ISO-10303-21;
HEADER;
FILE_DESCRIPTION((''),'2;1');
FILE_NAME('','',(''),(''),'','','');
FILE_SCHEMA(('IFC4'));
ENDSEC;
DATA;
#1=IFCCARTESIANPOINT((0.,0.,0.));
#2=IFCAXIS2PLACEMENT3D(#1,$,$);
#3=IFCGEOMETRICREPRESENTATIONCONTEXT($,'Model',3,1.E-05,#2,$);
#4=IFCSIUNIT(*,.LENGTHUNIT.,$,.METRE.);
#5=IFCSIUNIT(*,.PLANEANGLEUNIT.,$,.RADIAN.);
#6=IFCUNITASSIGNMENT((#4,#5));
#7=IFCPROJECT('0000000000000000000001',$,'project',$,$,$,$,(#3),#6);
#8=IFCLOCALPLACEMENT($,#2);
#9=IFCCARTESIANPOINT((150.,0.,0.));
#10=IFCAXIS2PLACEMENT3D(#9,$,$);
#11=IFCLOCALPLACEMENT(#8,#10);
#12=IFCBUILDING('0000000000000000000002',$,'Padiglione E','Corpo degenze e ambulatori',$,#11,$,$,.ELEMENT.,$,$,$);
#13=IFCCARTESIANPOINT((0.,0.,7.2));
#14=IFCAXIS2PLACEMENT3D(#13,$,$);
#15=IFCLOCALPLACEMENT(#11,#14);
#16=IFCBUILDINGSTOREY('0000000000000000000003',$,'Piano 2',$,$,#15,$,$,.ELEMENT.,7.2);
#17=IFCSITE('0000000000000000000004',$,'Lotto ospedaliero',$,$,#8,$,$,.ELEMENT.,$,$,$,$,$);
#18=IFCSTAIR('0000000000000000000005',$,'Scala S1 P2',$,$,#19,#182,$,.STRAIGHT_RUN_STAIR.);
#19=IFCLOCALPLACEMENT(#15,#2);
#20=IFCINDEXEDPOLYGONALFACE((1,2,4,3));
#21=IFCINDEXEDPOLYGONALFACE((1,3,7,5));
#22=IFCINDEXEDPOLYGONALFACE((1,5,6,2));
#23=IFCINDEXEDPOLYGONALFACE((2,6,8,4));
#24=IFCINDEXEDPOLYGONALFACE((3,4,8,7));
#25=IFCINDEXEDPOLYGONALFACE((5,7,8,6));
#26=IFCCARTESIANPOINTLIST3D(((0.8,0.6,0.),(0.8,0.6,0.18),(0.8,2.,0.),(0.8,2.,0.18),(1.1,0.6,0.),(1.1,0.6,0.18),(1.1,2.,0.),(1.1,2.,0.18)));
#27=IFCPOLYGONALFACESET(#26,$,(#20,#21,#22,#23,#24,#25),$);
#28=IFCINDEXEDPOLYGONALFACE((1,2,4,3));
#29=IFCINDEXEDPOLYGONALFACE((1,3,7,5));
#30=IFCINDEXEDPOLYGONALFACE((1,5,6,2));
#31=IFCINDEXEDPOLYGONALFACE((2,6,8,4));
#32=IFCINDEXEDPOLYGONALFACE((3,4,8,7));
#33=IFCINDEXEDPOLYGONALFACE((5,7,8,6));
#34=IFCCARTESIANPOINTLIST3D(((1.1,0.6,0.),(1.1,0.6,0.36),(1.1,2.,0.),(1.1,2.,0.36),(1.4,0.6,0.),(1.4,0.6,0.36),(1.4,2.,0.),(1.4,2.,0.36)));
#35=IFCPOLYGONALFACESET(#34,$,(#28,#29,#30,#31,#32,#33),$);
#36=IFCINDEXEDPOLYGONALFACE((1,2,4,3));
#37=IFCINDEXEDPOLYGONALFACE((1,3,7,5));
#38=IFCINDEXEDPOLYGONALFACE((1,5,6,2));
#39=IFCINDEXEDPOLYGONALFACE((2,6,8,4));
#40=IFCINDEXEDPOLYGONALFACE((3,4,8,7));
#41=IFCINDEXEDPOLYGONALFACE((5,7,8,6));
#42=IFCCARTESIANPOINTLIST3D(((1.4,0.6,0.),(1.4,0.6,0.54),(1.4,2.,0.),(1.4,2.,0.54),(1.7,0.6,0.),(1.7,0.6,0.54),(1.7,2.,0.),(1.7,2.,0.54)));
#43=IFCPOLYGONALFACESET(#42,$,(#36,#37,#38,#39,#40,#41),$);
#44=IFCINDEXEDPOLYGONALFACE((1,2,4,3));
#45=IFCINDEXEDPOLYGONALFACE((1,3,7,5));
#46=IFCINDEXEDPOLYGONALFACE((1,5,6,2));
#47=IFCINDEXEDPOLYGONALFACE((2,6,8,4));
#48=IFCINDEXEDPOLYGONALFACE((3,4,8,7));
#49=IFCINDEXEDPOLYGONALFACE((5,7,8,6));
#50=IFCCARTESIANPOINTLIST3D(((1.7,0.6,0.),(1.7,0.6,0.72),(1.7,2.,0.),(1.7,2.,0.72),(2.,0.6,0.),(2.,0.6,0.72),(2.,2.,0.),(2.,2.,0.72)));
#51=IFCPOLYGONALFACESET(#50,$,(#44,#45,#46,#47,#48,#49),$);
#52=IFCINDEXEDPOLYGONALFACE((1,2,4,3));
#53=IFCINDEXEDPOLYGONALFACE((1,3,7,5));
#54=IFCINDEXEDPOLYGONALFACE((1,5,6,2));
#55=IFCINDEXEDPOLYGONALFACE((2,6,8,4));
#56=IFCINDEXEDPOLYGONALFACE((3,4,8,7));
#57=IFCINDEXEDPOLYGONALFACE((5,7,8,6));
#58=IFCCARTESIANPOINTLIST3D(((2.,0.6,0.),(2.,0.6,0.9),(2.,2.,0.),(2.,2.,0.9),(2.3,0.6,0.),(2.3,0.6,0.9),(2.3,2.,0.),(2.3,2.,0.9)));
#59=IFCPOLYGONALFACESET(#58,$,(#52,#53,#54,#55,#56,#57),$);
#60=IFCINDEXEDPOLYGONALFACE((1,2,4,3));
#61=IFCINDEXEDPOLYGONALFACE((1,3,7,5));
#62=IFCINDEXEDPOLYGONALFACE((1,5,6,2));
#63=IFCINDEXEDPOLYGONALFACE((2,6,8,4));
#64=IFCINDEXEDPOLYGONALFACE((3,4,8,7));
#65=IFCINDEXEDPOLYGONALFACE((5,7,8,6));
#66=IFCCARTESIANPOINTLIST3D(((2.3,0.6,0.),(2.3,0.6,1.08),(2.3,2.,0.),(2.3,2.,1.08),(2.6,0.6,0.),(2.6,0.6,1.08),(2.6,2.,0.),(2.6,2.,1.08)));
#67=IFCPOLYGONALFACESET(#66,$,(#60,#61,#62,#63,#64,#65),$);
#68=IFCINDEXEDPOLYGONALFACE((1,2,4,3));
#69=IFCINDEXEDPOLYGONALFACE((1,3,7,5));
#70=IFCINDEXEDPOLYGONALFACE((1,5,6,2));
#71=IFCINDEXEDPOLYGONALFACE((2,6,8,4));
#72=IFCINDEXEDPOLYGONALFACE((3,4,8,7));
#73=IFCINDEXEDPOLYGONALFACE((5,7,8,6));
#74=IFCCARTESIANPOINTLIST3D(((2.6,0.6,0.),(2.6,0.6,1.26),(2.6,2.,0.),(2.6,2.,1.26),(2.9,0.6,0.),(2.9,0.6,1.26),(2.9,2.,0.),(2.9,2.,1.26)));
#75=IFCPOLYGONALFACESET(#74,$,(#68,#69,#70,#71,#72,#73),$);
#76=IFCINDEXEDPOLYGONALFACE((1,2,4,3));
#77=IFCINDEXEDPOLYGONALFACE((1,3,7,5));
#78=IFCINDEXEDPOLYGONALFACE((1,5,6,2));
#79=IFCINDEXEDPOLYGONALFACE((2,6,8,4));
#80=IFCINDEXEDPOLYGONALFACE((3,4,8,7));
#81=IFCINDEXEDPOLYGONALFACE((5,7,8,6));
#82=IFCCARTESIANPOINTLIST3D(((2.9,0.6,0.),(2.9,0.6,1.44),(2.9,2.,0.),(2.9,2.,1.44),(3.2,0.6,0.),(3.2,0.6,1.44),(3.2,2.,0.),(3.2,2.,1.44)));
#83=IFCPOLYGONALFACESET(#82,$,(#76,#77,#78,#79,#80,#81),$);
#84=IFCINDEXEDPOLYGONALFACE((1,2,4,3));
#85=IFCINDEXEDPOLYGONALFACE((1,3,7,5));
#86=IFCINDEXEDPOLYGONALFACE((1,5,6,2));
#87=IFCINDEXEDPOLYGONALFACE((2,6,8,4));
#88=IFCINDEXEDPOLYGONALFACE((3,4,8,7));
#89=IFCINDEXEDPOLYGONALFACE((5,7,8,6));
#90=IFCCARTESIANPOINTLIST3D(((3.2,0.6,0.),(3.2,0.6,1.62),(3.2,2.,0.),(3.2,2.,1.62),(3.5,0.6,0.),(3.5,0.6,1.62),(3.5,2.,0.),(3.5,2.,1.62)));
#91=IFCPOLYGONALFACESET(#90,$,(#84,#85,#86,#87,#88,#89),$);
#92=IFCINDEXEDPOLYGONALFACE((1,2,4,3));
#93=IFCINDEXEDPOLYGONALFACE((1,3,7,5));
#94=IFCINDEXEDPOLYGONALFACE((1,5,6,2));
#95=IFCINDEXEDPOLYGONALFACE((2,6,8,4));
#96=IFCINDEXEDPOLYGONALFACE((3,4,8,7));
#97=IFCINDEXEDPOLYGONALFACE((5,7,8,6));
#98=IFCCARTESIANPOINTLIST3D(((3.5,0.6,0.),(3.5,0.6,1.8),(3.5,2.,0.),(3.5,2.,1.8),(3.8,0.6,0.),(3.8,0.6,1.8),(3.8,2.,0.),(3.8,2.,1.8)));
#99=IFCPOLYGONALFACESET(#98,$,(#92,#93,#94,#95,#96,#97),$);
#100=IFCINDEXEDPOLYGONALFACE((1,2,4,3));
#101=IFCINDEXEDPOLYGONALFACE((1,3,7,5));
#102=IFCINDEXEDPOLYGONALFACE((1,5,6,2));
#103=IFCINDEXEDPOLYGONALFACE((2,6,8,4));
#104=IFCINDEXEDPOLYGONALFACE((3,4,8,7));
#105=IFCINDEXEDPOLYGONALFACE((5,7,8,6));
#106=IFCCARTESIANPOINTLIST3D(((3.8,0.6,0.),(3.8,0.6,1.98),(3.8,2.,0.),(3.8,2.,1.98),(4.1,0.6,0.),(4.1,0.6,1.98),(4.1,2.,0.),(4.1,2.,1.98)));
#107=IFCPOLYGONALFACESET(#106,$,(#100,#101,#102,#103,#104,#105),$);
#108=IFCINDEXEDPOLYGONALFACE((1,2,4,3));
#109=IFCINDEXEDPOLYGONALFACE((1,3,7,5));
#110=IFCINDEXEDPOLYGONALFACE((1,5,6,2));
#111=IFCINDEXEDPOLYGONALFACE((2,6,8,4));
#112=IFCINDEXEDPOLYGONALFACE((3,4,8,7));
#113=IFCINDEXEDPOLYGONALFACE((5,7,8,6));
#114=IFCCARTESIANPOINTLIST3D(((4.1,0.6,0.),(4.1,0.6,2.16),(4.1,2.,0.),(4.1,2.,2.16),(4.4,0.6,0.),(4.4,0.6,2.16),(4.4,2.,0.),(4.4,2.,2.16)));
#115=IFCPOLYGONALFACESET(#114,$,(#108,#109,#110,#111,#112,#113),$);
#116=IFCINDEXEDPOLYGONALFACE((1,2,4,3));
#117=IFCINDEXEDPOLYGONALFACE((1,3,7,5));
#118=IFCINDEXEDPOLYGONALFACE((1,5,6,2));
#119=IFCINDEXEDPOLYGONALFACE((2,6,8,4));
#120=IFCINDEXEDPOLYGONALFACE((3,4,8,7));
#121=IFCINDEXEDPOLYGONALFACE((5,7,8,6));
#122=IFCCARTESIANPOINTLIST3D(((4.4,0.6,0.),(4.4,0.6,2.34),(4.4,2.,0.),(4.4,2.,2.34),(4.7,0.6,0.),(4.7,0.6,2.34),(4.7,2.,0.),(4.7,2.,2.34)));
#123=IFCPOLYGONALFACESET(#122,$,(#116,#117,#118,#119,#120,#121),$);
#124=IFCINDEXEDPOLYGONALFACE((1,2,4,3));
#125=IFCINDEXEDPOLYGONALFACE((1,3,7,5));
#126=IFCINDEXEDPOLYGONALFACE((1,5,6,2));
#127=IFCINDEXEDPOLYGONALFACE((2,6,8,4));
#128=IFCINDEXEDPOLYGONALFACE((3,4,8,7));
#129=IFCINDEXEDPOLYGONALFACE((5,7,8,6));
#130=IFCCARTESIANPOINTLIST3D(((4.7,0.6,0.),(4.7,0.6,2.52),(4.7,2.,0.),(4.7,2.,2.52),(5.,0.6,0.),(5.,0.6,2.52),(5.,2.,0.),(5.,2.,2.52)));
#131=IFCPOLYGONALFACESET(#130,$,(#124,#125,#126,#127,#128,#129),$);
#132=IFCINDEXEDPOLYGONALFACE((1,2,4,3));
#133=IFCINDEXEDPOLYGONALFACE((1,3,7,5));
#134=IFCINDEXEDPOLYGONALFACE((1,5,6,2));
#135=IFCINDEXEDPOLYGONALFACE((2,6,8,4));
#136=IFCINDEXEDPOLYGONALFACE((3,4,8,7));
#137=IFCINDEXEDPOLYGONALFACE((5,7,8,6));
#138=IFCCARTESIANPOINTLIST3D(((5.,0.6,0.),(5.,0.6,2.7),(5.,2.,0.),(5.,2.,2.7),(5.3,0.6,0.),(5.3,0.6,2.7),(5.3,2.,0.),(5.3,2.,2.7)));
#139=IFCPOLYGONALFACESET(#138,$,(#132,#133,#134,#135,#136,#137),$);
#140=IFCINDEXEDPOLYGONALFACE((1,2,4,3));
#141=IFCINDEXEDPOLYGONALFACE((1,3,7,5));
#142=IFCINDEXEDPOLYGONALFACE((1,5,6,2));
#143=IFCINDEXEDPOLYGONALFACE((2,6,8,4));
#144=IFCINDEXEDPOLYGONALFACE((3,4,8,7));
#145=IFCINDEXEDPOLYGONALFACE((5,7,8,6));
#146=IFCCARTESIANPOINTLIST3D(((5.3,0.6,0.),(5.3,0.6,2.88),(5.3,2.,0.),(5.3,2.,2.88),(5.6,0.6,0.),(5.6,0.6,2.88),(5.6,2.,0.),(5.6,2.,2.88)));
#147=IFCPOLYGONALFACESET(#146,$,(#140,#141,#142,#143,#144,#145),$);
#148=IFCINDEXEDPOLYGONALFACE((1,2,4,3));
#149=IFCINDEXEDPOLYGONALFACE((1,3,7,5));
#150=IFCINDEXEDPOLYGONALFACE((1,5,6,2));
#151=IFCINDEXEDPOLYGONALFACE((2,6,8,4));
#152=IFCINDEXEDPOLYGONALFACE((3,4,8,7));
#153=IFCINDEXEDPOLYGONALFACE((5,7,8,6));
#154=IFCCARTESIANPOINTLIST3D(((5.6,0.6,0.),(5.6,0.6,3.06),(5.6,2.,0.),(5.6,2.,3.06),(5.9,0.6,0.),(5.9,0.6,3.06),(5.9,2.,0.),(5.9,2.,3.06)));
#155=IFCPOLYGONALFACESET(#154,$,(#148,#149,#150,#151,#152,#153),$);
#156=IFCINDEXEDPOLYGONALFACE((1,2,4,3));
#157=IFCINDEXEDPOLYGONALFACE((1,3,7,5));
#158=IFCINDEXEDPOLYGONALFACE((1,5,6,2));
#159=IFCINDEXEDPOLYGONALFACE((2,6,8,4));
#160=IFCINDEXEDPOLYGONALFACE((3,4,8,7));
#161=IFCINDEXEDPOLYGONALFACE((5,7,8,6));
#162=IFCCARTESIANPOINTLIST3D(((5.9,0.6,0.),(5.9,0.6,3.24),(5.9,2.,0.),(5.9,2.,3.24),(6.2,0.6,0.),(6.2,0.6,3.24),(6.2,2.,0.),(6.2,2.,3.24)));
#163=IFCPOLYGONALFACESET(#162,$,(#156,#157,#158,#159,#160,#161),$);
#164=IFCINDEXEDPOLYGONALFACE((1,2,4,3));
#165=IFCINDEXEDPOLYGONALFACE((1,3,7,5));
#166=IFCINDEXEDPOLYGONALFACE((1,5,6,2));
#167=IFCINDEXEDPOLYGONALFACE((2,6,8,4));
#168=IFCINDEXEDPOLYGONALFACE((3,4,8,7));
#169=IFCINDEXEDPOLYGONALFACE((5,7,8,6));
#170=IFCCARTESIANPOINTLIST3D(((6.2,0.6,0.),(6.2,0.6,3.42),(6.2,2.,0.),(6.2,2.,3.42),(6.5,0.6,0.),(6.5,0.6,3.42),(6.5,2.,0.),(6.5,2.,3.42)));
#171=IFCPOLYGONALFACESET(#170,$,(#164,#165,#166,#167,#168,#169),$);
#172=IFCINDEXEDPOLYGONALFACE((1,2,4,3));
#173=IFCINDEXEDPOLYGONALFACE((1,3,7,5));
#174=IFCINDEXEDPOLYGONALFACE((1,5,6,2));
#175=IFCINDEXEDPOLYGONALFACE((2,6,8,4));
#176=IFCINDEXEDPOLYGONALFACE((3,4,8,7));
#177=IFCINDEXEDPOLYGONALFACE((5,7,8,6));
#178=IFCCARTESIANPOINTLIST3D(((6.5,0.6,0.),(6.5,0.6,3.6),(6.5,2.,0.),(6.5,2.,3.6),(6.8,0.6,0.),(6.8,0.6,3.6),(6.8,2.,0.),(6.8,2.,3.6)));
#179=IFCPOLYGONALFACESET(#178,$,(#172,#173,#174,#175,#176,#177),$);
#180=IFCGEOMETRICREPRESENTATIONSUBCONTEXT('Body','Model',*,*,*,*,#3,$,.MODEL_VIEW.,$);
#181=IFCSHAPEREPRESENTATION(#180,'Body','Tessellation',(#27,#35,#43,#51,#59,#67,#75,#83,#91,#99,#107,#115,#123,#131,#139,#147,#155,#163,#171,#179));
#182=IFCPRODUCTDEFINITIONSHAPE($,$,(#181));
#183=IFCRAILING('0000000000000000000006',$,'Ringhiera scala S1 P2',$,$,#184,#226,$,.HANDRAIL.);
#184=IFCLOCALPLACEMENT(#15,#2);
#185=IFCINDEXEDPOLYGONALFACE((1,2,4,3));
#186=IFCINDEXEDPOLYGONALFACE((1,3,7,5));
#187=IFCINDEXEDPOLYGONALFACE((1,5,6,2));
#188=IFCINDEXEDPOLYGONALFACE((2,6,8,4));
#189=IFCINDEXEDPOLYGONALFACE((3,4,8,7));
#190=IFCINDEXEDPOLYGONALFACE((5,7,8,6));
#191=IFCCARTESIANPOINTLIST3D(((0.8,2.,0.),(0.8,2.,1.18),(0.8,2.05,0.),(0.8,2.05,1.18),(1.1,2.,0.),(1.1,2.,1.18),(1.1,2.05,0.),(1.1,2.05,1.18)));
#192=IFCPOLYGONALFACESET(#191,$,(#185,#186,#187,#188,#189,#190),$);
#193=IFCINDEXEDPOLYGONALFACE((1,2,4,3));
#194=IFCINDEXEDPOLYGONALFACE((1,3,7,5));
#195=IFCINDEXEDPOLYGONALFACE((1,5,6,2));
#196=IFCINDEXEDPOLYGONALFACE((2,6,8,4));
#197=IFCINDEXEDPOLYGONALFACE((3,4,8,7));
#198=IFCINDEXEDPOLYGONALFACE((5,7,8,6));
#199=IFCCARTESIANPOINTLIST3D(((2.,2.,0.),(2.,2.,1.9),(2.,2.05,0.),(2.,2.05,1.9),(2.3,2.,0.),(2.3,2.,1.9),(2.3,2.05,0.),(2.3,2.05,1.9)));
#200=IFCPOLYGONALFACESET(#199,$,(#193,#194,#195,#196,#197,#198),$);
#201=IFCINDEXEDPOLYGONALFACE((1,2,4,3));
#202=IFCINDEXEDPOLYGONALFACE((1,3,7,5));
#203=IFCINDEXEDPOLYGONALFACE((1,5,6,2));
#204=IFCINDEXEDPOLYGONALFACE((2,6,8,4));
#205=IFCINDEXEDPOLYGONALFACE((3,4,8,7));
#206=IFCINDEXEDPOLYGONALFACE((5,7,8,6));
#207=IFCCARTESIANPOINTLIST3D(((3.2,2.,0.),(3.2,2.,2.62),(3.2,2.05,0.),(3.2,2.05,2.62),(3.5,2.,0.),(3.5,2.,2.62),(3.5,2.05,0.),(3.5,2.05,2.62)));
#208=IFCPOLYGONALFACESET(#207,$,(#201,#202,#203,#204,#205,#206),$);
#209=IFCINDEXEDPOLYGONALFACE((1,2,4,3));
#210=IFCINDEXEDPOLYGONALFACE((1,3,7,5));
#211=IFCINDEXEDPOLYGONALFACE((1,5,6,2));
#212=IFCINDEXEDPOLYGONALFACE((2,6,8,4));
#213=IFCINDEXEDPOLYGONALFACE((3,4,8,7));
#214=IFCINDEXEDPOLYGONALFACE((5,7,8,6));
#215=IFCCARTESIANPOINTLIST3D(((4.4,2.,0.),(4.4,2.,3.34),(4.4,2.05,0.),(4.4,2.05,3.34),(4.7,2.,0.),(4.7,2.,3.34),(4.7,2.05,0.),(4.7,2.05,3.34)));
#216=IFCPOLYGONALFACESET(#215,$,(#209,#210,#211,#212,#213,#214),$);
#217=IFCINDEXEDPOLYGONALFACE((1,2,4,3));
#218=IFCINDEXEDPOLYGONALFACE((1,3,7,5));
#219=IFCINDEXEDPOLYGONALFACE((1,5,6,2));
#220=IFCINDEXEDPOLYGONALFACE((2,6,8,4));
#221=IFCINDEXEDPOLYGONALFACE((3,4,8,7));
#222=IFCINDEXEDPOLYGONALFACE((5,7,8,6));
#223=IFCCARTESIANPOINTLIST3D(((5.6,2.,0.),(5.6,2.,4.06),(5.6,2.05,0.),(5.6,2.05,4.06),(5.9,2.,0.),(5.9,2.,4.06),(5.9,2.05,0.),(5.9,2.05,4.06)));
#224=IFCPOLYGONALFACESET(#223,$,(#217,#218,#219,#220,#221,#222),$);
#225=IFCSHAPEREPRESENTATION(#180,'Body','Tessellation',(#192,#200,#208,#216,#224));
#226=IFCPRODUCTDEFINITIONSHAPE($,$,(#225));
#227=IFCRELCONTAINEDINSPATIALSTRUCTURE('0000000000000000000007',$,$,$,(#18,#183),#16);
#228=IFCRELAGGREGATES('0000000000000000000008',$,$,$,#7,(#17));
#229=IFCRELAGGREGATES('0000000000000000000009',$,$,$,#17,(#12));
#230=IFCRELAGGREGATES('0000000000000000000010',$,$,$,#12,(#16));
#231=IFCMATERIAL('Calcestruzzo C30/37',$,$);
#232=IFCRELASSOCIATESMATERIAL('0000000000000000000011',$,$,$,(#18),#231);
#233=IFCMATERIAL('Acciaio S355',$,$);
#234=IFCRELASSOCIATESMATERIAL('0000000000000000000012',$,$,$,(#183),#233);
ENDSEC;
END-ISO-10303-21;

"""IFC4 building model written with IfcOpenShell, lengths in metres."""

from ifc_helpers import new_model, si_unit, frame, frame_2d, origin, place, context, subcontext, project, spatial, rectangle, extrude, material, element, save


model = new_model("IFC4")

# Units and contexts
model_context = context("Model", 3, precision=1e-05, world=origin())
body_context = subcontext(model_context, "Body", "Model", "MODEL_VIEW")
ifc_project = project(units=[si_unit("LENGTHUNIT", "METRE"), si_unit("PLANEANGLEUNIT", "RADIAN")], contexts=[model_context])

# Site, building, storey
site_placement = place(None, origin())
site = spatial("IfcSite", under=ifc_project, at=site_placement, Name="Lotto ospedaliero", CompositionType="ELEMENT")
building_placement = place(site_placement, frame((150.0, 0.0, 0.0)))
building = spatial("IfcBuilding", under=site, at=building_placement, Name="Padiglione E", Description="Corpo degenze e ambulatori", CompositionType="ELEMENT")
storey_placement = place(building_placement, frame((0.0, 0.0, 7.2)))
storey = spatial("IfcBuildingStorey", under=building, at=storey_placement, Name="Piano 2", CompositionType="ELEMENT", Elevation=7.2)

# Shared definitions
ifc_material_1 = material(Name="Calcestruzzo C30/37")

# Stair
stair_placement = place(storey_placement, frame((0.8, 0.6, 0.0)))
element("IfcStair", 1, at=stair_placement, inside=storey, material=ifc_material_1, Name="Scala S1 P2", PredefinedType="STRAIGHT_RUN_STAIR", context=body_context, shape_type="SweptSolid", body=[
    extrude(rectangle(XDim=0.3, YDim=1.4, at=frame_2d((0.15, 0.7))), origin(), (0.0, 0.0, 1.0), 0.18),
    extrude(rectangle(XDim=0.3, YDim=1.4, at=frame_2d((0.15, 0.7))), frame((0.3, 0.0, 0.0)), (0.0, 0.0, 1.0), 0.36),
    extrude(rectangle(XDim=0.3, YDim=1.4, at=frame_2d((0.15, 0.7))), frame((0.6, 0.0, 0.0)), (0.0, 0.0, 1.0), 0.54),
    extrude(rectangle(XDim=0.3, YDim=1.4, at=frame_2d((0.15, 0.7))), frame((0.9, 0.0, 0.0)), (0.0, 0.0, 1.0), 0.72),
    extrude(rectangle(XDim=0.3, YDim=1.4, at=frame_2d((0.15, 0.7))), frame((1.2, 0.0, 0.0)), (0.0, 0.0, 1.0), 0.9),
    extrude(rectangle(XDim=0.3, YDim=1.4, at=frame_2d((0.15, 0.7))), frame((1.5, 0.0, 0.0)), (0.0, 0.0, 1.0), 1.08),
    extrude(rectangle(XDim=0.3, YDim=1.4, at=frame_2d((0.15, 0.7))), frame((1.8, 0.0, 0.0)), (0.0, 0.0, 1.0), 1.26),
    extrude(rectangle(XDim=0.3, YDim=1.4, at=frame_2d((0.15, 0.7))), frame((2.1, 0.0, 0.0)), (0.0, 0.0, 1.0), 1.44),
    extrude(rectangle(XDim=0.3, YDim=1.4, at=frame_2d((0.15, 0.7))), frame((2.4, 0.0, 0.0)), (0.0, 0.0, 1.0), 1.62),
    extrude(rectangle(XDim=0.3, YDim=1.4, at=frame_2d((0.15, 0.7))), frame((2.7, 0.0, 0.0)), (0.0, 0.0, 1.0), 1.8),
    extrude(rectangle(XDim=0.3, YDim=1.4, at=frame_2d((0.15, 0.7))), frame((3.0, 0.0, 0.0)), (0.0, 0.0, 1.0), 1.98),
    extrude(rectangle(XDim=0.3, YDim=1.4, at=frame_2d((0.15, 0.7))), frame((3.3, 0.0, 0.0)), (0.0, 0.0, 1.0), 2.16),
    extrude(rectangle(XDim=0.3, YDim=1.4, at=frame_2d((0.15, 0.7))), frame((3.6, 0.0, 0.0)), (0.0, 0.0, 1.0), 2.34),
    extrude(rectangle(XDim=0.3, YDim=1.4, at=frame_2d((0.15, 0.7))), frame((3.9, 0.0, 0.0)), (0.0, 0.0, 1.0), 2.52),
    extrude(rectangle(XDim=0.3, YDim=1.4, at=frame_2d((0.15, 0.7))), frame((4.2, 0.0, 0.0)), (0.0, 0.0, 1.0), 2.7),
    extrude(rectangle(XDim=0.3, YDim=1.4, at=frame_2d((0.15, 0.7))), frame((4.5, 0.0, 0.0)), (0.0, 0.0, 1.0), 2.88),
    extrude(rectangle(XDim=0.3, YDim=1.4, at=frame_2d((0.15, 0.7))), frame((4.8, 0.0, 0.0)), (0.0, 0.0, 1.0), 3.06),
    extrude(rectangle(XDim=0.3, YDim=1.4, at=frame_2d((0.15, 0.7))), frame((5.1, 0.0, 0.0)), (0.0, 0.0, 1.0), 3.24),
    extrude(rectangle(XDim=0.3, YDim=1.4, at=frame_2d((0.15, 0.7))), frame((5.4, 0.0, 0.0)), (0.0, 0.0, 1.0), 3.42),
    extrude(rectangle(XDim=0.3, YDim=1.4, at=frame_2d((0.15, 0.7))), frame((5.7, 0.0, 0.0)), (0.0, 0.0, 1.0), 3.6),
])

# Railing
ifc_material_2 = material(Name="Acciaio S355")
railing_placement = place(storey_placement, frame((0.8, 2.0, 0.0)))
element("IfcRailing", 2, at=railing_placement, inside=storey, material=ifc_material_2, Name="Ringhiera scala S1 P2", PredefinedType="HANDRAIL", context=body_context, shape_type="SweptSolid", body=[
    extrude(rectangle(XDim=0.3, YDim=0.05, at=frame_2d((0.15, 0.025))), origin(), (0.0, 0.0, 1.0), 1.18),
    extrude(rectangle(XDim=0.3, YDim=0.05, at=frame_2d((0.15, 0.025))), frame((1.2, 0.0, 0.0)), (0.0, 0.0, 1.0), 1.9),
    extrude(rectangle(XDim=0.3, YDim=0.05, at=frame_2d((0.15, 0.025))), frame((2.4, 0.0, 0.0)), (0.0, 0.0, 1.0), 2.62),
    extrude(rectangle(XDim=0.3, YDim=0.05, at=frame_2d((0.15, 0.025))), frame((3.6, 0.0, 0.0)), (0.0, 0.0, 1.0), 3.34),
    extrude(rectangle(XDim=0.3, YDim=0.05, at=frame_2d((0.15, 0.025))), frame((4.8, 0.0, 0.0)), (0.0, 0.0, 1.0), 4.06),
])

save(model, "model.ifc")
